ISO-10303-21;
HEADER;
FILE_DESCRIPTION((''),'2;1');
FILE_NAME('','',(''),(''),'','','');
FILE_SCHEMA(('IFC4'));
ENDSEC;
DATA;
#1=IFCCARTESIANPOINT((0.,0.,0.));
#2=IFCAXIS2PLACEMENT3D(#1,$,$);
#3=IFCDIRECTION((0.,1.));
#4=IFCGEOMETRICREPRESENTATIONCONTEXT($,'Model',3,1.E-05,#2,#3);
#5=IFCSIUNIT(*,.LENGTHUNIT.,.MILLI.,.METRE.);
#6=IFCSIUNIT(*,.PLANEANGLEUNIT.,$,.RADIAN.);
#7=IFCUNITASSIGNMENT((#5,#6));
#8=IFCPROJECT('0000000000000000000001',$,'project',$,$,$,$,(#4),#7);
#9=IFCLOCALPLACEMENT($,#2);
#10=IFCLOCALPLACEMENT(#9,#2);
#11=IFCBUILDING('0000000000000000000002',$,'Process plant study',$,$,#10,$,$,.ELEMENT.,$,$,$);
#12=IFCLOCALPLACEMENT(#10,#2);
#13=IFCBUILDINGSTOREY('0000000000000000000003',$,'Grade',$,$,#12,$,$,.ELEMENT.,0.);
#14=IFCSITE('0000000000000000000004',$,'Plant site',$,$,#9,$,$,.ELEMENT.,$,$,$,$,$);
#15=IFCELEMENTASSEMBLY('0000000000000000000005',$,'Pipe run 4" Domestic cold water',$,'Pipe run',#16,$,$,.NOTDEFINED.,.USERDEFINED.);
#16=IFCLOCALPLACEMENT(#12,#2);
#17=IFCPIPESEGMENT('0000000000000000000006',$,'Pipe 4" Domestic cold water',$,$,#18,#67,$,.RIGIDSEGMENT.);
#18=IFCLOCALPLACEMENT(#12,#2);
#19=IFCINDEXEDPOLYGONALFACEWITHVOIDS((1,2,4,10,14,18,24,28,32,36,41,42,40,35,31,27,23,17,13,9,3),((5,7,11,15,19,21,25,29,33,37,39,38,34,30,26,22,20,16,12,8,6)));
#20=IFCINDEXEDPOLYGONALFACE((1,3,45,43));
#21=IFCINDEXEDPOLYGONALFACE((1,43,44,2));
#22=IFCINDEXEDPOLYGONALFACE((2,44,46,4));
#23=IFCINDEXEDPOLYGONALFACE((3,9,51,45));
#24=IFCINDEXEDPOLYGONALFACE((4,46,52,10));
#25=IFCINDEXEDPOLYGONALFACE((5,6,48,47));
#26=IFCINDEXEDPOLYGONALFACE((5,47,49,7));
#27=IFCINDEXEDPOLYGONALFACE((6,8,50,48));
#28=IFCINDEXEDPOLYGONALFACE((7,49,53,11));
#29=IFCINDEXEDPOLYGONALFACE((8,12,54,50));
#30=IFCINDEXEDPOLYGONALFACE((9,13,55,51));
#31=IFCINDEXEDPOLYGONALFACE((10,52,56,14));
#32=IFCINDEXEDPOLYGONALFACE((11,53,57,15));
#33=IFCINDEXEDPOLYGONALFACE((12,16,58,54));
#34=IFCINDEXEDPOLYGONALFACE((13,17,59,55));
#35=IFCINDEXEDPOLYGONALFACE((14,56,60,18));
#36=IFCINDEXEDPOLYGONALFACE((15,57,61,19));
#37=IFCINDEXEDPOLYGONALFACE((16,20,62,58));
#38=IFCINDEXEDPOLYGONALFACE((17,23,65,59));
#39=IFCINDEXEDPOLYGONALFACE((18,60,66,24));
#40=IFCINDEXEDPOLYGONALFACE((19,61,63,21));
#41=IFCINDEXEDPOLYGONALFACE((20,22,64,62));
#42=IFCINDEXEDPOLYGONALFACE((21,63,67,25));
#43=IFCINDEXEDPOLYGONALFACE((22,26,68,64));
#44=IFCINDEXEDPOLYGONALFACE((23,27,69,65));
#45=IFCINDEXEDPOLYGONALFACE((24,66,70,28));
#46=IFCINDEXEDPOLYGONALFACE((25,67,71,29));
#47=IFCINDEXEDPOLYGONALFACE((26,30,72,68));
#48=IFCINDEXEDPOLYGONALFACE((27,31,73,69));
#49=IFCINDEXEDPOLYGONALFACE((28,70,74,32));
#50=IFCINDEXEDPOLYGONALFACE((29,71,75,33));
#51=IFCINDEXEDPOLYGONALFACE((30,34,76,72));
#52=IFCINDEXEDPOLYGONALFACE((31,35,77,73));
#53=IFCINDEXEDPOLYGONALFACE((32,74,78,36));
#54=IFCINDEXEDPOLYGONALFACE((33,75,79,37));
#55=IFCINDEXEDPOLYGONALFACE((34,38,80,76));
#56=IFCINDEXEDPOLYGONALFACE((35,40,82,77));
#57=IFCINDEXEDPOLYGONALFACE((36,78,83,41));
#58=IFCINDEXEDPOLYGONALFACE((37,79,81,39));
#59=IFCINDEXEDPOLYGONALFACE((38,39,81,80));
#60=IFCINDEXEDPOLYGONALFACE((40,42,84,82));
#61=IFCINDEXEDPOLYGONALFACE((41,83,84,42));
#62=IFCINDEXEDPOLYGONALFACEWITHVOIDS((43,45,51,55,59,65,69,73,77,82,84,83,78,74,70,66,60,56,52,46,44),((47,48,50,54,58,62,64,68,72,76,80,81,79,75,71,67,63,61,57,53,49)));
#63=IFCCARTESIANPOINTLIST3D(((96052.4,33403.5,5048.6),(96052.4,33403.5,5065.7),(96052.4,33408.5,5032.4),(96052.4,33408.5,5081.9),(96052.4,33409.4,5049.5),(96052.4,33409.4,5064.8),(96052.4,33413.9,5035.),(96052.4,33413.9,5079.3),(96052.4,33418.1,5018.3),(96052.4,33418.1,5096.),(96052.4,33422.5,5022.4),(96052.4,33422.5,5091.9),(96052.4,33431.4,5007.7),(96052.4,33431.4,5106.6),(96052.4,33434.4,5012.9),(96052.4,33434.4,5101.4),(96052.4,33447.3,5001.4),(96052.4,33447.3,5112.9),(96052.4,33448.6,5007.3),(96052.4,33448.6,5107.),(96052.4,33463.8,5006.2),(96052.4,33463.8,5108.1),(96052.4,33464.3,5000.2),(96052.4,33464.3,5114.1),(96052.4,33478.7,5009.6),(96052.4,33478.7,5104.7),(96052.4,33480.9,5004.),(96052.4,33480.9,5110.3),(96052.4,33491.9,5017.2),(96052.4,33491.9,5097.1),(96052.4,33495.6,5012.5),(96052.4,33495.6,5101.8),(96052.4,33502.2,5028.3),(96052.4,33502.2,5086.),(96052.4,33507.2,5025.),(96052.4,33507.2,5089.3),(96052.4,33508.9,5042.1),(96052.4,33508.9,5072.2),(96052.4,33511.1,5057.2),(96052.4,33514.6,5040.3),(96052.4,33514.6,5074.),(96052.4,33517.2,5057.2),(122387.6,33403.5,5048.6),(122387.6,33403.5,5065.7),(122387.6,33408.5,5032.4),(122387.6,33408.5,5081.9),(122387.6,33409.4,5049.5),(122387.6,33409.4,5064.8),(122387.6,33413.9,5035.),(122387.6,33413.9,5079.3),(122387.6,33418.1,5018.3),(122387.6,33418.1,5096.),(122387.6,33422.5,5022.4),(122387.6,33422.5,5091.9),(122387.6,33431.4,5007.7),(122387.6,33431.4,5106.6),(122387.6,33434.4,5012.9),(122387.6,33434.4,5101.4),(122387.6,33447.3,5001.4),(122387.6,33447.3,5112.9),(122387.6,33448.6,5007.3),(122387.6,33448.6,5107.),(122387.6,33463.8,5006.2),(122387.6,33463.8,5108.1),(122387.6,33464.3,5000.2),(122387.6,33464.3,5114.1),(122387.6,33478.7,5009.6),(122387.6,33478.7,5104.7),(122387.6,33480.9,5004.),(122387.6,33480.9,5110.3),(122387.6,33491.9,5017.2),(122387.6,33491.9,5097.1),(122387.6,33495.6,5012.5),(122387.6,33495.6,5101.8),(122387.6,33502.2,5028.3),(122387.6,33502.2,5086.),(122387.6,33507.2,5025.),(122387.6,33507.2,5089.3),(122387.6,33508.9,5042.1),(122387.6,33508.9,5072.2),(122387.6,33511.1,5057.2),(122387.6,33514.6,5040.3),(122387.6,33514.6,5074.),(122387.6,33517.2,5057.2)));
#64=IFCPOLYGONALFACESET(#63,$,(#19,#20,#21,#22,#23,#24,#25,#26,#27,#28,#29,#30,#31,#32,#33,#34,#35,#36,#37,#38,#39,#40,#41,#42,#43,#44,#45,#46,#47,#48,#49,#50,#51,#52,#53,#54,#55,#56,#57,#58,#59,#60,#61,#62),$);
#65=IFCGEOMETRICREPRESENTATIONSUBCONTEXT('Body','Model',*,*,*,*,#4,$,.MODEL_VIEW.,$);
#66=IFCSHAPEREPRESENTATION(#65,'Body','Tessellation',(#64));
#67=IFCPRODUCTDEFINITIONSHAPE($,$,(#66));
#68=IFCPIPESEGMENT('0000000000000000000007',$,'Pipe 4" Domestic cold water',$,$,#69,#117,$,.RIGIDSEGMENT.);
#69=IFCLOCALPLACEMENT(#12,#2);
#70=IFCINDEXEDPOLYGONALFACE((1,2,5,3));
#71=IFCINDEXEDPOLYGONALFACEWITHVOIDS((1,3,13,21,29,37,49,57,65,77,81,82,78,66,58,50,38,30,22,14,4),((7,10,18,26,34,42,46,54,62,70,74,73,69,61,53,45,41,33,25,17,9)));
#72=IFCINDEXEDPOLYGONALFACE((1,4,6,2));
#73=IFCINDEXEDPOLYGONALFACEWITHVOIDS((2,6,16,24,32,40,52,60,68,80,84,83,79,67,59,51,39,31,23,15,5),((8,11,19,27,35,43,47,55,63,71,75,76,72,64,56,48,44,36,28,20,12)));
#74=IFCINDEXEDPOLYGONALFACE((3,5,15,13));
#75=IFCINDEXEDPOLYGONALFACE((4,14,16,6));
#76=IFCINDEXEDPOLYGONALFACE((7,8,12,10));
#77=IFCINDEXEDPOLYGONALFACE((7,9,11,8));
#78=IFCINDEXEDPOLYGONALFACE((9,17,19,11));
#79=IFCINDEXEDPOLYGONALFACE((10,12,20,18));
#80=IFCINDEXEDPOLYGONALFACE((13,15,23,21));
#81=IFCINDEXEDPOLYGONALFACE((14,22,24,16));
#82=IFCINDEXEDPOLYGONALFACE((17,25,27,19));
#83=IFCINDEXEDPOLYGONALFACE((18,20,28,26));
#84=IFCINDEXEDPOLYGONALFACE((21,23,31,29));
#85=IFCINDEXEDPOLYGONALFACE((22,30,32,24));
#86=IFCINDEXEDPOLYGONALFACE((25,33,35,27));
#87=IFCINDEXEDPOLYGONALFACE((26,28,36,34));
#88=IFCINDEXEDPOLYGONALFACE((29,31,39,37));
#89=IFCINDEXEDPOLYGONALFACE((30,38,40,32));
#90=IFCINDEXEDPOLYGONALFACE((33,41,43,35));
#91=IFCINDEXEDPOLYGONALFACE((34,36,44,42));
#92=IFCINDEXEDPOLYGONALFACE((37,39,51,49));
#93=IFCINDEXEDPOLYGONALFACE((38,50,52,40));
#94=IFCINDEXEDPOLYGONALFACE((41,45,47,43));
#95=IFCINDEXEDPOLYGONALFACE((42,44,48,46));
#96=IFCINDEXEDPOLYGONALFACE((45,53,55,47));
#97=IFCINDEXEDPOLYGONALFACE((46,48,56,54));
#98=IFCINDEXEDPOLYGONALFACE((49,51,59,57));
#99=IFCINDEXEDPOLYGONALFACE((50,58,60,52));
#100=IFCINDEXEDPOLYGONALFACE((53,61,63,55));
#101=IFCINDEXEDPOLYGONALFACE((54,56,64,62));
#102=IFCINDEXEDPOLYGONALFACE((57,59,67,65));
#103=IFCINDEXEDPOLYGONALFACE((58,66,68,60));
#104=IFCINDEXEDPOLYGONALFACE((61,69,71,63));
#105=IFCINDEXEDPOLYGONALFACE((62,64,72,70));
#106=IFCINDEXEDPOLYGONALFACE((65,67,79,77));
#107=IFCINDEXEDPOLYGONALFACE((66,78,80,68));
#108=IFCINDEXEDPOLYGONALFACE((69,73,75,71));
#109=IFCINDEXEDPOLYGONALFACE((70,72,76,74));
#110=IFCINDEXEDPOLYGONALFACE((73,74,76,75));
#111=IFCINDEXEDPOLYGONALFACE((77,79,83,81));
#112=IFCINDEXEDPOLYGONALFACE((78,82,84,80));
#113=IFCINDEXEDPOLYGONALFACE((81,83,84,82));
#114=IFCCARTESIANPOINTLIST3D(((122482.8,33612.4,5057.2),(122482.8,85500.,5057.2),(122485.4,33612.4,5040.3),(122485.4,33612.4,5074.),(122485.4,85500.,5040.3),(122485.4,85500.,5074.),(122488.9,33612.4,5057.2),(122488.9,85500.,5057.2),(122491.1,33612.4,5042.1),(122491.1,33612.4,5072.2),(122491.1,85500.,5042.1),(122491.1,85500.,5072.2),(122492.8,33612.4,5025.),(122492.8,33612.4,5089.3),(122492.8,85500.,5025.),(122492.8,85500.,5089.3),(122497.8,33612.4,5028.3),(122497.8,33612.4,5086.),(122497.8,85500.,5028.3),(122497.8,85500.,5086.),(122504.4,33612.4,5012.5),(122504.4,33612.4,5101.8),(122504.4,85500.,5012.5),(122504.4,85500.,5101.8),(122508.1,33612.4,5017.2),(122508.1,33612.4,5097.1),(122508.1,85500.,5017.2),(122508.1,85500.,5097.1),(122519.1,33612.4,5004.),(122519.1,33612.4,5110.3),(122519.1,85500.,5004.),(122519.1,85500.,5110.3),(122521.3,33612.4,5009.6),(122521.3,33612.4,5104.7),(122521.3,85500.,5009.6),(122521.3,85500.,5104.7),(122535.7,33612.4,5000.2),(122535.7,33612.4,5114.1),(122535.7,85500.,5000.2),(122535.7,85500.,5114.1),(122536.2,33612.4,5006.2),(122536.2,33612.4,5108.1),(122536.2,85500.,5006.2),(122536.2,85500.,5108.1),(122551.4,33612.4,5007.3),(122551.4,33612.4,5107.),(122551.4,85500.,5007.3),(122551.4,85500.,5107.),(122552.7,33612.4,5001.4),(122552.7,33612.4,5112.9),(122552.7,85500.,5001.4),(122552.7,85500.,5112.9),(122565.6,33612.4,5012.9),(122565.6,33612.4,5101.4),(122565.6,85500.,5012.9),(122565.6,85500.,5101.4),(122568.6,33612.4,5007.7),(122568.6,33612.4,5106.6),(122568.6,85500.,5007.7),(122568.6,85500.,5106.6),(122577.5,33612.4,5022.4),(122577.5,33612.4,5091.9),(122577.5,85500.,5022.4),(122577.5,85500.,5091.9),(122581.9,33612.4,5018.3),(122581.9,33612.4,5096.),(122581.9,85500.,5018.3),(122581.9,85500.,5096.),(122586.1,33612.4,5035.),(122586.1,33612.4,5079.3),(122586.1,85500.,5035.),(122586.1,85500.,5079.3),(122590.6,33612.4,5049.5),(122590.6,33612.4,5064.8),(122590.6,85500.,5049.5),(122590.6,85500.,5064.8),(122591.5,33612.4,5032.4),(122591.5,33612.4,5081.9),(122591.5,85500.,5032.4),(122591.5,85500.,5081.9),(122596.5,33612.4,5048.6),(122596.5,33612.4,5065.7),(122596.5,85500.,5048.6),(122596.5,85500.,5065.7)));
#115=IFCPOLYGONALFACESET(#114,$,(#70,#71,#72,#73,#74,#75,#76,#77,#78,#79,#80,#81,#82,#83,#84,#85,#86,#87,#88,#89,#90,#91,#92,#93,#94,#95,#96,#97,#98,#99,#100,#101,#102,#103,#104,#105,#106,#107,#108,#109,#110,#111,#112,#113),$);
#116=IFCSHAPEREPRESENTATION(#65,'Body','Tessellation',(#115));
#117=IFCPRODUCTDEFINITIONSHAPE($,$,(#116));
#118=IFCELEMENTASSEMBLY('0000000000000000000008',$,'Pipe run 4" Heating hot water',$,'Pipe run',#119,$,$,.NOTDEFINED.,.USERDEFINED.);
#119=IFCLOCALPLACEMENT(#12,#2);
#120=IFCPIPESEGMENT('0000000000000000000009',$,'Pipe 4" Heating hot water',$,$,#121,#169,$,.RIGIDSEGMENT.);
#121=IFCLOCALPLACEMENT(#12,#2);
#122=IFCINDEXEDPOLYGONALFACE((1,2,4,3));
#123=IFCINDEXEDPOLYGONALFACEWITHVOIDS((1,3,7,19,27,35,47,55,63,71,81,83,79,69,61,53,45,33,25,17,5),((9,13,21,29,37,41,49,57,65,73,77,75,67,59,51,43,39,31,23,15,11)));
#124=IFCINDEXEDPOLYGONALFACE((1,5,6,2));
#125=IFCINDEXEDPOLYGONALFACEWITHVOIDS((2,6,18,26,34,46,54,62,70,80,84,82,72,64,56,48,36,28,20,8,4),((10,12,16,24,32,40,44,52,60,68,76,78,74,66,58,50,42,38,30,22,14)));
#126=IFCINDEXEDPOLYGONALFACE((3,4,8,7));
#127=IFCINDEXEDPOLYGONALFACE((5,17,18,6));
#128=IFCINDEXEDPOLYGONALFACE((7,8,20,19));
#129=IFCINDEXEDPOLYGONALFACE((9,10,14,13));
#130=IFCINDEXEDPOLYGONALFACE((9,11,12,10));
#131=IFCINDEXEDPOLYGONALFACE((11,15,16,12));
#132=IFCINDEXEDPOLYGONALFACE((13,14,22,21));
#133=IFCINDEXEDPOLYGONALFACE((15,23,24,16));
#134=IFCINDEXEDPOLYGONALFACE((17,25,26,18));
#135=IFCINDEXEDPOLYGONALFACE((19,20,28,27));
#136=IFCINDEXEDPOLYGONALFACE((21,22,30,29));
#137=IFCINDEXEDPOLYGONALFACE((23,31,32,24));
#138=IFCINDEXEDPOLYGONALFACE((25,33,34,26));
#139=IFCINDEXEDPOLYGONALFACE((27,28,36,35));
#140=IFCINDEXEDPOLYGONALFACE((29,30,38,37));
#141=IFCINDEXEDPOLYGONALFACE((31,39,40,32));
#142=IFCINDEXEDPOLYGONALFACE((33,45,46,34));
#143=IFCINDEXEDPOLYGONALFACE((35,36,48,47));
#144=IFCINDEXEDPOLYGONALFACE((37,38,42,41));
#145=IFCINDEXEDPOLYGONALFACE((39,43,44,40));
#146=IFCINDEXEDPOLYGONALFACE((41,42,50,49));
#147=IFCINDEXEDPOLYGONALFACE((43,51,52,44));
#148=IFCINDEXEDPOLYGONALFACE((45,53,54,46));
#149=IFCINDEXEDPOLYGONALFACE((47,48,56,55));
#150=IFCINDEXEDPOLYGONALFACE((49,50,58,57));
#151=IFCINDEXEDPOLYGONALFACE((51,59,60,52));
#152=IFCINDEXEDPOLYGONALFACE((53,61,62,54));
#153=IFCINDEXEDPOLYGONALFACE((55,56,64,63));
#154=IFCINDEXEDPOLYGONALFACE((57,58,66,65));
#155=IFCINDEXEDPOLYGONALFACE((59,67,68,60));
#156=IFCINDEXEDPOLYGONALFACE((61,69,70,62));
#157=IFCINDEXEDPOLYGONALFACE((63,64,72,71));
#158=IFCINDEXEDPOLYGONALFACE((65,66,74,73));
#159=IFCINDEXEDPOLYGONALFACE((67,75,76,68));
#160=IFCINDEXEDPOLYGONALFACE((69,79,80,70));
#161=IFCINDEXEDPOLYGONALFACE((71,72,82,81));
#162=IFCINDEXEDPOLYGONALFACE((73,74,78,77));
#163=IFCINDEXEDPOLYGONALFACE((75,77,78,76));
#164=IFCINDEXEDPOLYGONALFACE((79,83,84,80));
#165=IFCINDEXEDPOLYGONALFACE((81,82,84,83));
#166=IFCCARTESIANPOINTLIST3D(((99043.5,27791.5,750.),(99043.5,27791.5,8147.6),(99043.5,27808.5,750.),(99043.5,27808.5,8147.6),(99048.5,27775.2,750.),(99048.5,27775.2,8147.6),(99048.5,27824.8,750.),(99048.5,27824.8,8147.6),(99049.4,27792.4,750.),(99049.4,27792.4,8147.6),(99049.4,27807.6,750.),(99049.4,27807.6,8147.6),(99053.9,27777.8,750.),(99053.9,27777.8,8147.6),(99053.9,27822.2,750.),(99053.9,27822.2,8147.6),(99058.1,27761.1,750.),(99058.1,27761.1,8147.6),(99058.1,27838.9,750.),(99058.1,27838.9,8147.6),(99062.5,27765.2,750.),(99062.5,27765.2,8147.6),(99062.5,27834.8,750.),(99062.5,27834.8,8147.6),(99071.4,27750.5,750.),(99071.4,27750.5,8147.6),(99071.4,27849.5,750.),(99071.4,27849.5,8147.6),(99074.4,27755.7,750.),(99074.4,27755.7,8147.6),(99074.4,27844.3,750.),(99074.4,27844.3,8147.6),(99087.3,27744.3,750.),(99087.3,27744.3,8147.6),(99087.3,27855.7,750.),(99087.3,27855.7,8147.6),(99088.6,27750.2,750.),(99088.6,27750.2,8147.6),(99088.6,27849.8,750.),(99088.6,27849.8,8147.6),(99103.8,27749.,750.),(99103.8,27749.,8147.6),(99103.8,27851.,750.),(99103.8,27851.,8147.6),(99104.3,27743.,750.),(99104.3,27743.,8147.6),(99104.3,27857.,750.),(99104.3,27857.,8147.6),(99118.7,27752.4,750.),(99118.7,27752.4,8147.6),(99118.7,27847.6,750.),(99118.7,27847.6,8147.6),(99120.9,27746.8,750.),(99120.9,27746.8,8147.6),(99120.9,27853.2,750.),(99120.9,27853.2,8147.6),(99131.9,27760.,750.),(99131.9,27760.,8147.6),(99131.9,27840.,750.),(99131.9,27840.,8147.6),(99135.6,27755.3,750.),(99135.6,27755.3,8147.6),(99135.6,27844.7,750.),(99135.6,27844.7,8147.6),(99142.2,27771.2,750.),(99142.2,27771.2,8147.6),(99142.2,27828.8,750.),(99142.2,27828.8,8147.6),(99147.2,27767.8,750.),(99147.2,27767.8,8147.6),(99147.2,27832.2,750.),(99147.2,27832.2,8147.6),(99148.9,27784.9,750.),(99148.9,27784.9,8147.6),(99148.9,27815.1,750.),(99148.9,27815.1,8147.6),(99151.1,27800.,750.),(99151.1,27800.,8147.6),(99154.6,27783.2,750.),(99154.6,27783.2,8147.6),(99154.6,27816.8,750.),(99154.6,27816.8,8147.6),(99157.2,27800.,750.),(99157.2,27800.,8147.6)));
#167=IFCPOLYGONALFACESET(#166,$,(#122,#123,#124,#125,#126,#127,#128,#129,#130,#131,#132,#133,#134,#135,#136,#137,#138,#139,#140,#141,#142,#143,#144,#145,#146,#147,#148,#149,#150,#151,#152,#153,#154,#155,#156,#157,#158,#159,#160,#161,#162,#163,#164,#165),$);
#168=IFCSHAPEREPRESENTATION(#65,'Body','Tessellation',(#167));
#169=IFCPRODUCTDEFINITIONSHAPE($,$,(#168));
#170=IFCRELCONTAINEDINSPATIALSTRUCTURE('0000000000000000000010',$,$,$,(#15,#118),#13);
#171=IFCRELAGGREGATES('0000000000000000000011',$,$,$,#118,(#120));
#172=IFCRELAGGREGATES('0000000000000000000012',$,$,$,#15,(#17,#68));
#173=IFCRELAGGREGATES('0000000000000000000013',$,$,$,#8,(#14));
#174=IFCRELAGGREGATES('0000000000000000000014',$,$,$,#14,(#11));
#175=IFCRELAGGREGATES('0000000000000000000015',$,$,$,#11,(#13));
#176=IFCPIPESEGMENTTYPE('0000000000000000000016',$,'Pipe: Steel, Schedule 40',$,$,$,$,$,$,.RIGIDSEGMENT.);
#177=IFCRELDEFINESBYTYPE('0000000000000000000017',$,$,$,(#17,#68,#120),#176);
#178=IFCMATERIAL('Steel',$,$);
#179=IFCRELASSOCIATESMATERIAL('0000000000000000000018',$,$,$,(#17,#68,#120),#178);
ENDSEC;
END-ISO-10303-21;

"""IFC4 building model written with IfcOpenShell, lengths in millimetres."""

from ifc_helpers import new_model, si_unit, direction, frame, origin, origin_with_axes, origin_2d, place, context, subcontext, project, spatial, hollow_circle, extrude, material, type_object, element, aggregate, save


model = new_model("IFC4")

# Units and contexts
model_context = context("Model", 3, precision=1e-05, world=origin(), true_north=direction((0.0, 1.0)))
body_context = subcontext(model_context, "Body", "Model", "MODEL_VIEW")
ifc_project = project(units=[si_unit("LENGTHUNIT", "METRE", prefix="MILLI"), si_unit("PLANEANGLEUNIT", "RADIAN")], contexts=[model_context])

# Site, building, storey
site_placement = place(None, origin())
site = spatial("IfcSite", under=ifc_project, at=site_placement, Name="Plant site", CompositionType="ELEMENT")
building_placement = place(site_placement, origin())
building = spatial("IfcBuilding", under=site, at=building_placement, Name="Process plant study", CompositionType="ELEMENT")
storey_placement = place(building_placement, origin())
storey = spatial("IfcBuildingStorey", under=building, at=storey_placement, Name="Grade", CompositionType="ELEMENT", Elevation=0.0)

# Element assembly, pipe segments
ifc_material = material(Name="Steel")
pipe_segment_type = type_object("IfcPipeSegmentType", Name="Pipe: Steel, Schedule 40", PredefinedType="RIGIDSEGMENT")
assembly_1_placement = place(storey_placement, origin_with_axes())
assembly_1 = element("IfcElementAssembly", 1, at=assembly_1_placement, inside=storey, Name="Pipe run 4\" Domestic cold water", ObjectType="Pipe run", AssemblyPlace="NOTDEFINED", PredefinedType="USERDEFINED")
pipe_segment_1_placement = place(storey_placement, origin_with_axes())
pipe_segment_1 = element("IfcPipeSegment", 2, at=pipe_segment_1_placement, type_object=pipe_segment_type, material=ifc_material, Name="Pipe 4\" Domestic cold water", PredefinedType="RIGIDSEGMENT", context=body_context, shape_type="SweptSolid", body=[
    extrude(hollow_circle(Radius=57.1, WallThickness=6.0, at=origin_2d()), frame((96052.4, 33460.0, 5057.1), z_axis=(1.0, 0.0, 0.0), x_axis=(0.0, 1.0, 0.0)), (0.0, 0.0, 1.0), 26335.2),
])
pipe_segment_2_placement = place(storey_placement, origin_with_axes())
pipe_segment_2 = element("IfcPipeSegment", 3, at=pipe_segment_2_placement, type_object=pipe_segment_type, material=ifc_material, Name="Pipe 4\" Domestic cold water", PredefinedType="RIGIDSEGMENT", context=body_context, shape_type="SweptSolid", body=[
    extrude(hollow_circle(Radius=57.1, WallThickness=6.0, at=origin_2d()), frame((122540.0, 33612.4, 5057.1), z_axis=(0.0, 1.0, 0.0), x_axis=(-1.0, 0.0, 0.0)), (0.0, 0.0, 1.0), 51887.6),
])

# Element assembly, pipe segment
assembly_2_placement = place(storey_placement, origin_with_axes())
assembly_2 = element("IfcElementAssembly", 4, at=assembly_2_placement, inside=storey, Name="Pipe run 4\" Heating hot water", ObjectType="Pipe run", AssemblyPlace="NOTDEFINED", PredefinedType="USERDEFINED")
pipe_segment_3_placement = place(storey_placement, origin_with_axes())
pipe_segment_3 = element("IfcPipeSegment", 5, at=pipe_segment_3_placement, type_object=pipe_segment_type, material=ifc_material, Name="Pipe 4\" Heating hot water", PredefinedType="RIGIDSEGMENT", context=body_context, shape_type="SweptSolid", body=[
    extrude(hollow_circle(Radius=57.1, WallThickness=6.0, at=origin_2d()), frame((99100.0, 27800.0, 750.0), z_axis=(0.0, 0.0, 1.0), x_axis=(1.0, 0.0, 0.0)), (0.0, 0.0, 1.0), 7397.6),
])
aggregate(assembly_2, [pipe_segment_3])

aggregate(assembly_1, [pipe_segment_1, pipe_segment_2])

save(model, "model.ifc")
